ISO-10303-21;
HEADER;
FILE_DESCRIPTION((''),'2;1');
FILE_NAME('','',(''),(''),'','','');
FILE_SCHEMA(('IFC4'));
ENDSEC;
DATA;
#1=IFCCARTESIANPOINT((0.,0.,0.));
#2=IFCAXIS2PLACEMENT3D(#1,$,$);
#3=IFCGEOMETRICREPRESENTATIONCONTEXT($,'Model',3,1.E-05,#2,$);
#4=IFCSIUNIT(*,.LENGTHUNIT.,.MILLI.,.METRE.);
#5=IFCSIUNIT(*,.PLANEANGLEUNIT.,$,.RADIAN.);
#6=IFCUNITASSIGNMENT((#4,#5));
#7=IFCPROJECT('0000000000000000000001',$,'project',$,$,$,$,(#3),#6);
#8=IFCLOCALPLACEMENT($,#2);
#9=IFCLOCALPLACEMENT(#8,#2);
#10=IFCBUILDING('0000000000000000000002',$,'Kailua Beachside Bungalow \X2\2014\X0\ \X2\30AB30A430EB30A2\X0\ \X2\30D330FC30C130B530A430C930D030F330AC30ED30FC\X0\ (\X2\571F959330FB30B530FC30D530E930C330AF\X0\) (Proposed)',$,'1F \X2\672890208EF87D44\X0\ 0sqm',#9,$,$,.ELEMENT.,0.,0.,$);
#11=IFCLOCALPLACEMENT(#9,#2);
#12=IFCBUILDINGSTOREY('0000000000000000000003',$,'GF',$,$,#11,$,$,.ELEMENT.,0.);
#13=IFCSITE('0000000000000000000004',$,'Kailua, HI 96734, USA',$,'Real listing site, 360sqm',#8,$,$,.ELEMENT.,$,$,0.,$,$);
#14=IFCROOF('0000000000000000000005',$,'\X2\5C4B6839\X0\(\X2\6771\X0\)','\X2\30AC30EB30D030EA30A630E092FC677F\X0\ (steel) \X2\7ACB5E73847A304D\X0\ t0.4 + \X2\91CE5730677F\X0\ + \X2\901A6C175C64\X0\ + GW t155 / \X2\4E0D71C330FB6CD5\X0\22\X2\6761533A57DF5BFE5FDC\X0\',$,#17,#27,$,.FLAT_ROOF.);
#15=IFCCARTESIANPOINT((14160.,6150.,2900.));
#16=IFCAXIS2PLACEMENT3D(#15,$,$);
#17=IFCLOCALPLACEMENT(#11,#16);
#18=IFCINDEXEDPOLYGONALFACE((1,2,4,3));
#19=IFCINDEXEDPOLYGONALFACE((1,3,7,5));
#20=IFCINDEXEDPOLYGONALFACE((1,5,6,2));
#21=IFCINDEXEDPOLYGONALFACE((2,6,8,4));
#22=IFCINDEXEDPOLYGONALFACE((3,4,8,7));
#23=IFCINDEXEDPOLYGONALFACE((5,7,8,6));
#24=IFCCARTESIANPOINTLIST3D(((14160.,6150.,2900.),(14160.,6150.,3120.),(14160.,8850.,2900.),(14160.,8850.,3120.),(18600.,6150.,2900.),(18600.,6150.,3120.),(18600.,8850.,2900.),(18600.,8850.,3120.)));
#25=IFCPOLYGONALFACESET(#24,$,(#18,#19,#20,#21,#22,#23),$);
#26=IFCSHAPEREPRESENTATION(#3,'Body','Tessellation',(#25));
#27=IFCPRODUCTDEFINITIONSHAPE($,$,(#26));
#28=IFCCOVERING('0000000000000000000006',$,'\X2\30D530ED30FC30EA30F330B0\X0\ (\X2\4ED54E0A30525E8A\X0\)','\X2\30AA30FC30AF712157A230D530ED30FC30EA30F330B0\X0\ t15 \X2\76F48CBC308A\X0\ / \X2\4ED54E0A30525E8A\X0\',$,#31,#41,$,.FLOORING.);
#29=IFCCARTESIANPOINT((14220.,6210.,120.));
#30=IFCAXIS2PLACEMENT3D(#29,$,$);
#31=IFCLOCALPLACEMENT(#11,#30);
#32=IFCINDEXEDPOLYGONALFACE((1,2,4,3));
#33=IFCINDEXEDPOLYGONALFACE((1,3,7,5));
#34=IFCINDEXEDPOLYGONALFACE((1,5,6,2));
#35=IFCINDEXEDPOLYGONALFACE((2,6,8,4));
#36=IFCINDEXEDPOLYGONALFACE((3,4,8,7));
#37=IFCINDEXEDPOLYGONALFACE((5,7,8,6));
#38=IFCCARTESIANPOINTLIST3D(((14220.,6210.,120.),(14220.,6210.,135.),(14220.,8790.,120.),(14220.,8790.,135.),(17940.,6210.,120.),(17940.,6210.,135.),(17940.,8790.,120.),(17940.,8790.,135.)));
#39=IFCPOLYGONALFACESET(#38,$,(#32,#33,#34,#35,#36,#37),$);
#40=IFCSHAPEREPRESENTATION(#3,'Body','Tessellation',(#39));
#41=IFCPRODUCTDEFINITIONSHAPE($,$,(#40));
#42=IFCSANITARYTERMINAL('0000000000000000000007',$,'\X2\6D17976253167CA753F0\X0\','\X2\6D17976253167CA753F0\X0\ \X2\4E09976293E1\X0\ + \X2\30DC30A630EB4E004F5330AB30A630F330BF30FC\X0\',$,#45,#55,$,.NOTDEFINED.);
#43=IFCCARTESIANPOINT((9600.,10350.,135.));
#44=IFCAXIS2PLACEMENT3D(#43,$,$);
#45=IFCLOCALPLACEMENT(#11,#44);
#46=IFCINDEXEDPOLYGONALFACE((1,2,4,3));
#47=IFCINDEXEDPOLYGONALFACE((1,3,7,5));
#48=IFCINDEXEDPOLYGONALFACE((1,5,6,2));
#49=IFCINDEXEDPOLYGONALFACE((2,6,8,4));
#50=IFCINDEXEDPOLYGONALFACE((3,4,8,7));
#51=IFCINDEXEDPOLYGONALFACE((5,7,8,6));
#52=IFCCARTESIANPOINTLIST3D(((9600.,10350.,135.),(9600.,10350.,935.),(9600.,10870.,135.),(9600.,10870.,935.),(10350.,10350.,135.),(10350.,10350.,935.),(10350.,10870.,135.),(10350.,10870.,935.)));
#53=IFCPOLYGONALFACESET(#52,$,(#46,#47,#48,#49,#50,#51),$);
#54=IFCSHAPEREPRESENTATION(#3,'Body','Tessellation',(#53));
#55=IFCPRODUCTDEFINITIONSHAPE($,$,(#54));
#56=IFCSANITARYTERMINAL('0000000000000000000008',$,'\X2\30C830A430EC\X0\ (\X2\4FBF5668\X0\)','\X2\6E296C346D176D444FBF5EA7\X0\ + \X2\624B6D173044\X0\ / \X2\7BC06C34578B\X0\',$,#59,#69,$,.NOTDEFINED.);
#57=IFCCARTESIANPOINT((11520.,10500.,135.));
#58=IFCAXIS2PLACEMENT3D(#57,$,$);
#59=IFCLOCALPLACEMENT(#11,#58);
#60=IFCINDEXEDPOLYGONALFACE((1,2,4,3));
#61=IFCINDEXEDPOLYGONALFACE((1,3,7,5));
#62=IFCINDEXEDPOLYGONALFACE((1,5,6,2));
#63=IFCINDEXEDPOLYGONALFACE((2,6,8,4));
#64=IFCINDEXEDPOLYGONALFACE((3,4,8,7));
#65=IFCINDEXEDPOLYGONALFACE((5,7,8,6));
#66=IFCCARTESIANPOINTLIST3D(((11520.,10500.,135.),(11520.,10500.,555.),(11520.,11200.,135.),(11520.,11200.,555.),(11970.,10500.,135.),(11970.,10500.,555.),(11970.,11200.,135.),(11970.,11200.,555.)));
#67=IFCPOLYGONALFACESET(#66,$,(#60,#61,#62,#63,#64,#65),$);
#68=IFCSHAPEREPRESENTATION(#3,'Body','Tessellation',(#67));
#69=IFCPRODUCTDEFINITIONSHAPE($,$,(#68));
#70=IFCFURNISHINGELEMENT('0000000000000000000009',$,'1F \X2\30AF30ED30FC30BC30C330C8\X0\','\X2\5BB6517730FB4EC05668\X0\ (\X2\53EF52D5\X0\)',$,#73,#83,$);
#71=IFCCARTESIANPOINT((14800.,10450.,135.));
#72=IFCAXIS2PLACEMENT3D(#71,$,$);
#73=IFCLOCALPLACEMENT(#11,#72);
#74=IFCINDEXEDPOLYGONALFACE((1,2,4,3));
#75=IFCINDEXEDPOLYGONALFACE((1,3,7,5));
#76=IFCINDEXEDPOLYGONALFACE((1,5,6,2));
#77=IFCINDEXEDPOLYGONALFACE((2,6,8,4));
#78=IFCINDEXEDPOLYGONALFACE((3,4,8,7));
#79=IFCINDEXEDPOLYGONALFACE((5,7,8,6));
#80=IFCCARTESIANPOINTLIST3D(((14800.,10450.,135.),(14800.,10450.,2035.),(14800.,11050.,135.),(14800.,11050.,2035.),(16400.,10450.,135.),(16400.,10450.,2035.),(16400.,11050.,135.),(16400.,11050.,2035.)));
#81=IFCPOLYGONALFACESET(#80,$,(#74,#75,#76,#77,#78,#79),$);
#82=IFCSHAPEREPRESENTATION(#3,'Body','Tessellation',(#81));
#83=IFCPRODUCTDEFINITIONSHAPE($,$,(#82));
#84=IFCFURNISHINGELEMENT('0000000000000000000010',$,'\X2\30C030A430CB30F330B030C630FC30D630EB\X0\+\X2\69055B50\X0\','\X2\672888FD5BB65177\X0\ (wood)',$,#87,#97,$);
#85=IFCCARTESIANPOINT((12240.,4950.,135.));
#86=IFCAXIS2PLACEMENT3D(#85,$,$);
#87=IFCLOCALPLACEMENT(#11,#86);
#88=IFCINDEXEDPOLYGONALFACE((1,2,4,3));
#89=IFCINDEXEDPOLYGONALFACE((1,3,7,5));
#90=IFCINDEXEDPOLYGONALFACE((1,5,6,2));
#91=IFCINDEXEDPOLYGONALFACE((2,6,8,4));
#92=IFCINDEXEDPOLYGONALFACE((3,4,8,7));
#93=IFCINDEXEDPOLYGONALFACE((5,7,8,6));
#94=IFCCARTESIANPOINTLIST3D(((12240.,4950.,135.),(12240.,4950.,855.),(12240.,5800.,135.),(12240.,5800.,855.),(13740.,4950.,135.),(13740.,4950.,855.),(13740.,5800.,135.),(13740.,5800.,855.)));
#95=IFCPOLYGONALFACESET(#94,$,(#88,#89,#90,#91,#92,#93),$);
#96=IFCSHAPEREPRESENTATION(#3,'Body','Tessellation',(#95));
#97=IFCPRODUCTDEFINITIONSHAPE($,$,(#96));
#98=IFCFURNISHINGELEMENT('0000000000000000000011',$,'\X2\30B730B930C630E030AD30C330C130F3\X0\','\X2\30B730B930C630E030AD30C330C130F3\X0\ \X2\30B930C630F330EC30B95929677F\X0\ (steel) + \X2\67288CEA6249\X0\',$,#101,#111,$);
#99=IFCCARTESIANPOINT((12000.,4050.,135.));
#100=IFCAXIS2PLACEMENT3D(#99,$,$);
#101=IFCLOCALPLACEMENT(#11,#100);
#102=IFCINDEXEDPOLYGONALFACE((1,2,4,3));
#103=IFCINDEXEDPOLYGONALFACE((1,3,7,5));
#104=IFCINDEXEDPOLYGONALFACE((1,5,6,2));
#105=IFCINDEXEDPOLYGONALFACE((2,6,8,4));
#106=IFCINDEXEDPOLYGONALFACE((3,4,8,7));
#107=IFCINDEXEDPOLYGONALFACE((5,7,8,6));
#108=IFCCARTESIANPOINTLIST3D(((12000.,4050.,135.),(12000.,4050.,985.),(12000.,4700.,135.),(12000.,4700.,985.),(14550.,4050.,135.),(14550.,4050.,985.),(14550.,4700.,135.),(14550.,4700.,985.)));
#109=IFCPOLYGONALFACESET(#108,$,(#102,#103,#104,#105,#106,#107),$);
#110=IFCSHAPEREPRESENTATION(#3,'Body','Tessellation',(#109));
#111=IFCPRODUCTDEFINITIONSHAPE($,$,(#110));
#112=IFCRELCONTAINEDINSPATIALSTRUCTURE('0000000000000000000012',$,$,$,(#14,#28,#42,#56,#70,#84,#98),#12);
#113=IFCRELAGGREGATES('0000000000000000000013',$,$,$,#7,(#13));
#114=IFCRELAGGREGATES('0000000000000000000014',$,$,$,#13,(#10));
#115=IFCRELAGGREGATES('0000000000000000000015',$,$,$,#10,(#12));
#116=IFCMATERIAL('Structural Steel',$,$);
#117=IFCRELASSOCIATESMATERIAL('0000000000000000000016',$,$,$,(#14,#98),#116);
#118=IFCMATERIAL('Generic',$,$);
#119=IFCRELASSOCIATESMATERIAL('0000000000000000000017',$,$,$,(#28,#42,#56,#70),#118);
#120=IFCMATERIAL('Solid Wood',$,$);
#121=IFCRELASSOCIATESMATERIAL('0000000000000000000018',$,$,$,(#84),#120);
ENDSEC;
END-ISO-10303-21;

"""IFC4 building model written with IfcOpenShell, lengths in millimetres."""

from ifc_helpers import new_model, si_unit, frame, frame_2d, origin, place, context, project, spatial, rectangle, extrude, material, element, save


model = new_model("IFC4")

# Units and contexts
model_context = context("Model", 3, precision=1e-05, world=origin())
ifc_project = project(units=[si_unit("LENGTHUNIT", "METRE", prefix="MILLI"), si_unit("PLANEANGLEUNIT", "RADIAN")], contexts=[model_context])

# Site, building, storey
site_placement = place(None, origin())
site = spatial("IfcSite", under=ifc_project, at=site_placement, Name="Kailua, HI 96734, USA", ObjectType="Real listing site, 360sqm", CompositionType="ELEMENT", RefElevation=0.0)
building_placement = place(site_placement, origin())
building = spatial("IfcBuilding", under=site, at=building_placement, Name="Kailua Beachside Bungalow — カイルア ビーチサイドバンガロー (土間・サーフラック) (Proposed)", ObjectType="1F 木造軸組 0sqm", CompositionType="ELEMENT", ElevationOfRefHeight=0.0, ElevationOfTerrain=0.0)
storey_placement = place(building_placement, origin())
storey = spatial("IfcBuildingStorey", under=building, at=storey_placement, Name="GF", CompositionType="ELEMENT", Elevation=0.0)

# Shared definitions
ifc_material_1 = material(Name="Solid Wood")

# Roof
ifc_material_2 = material(Name="Structural Steel")
roof_placement = place(storey_placement, frame((14160.0, 6150.0, 2900.0)))
element("IfcRoof", 1, at=roof_placement, inside=storey, material=ifc_material_2, Name="屋根(東)", Description="ガルバリウム鋼板 (steel) 立平葺き t0.4 + 野地板 + 通気層 + GW t155 / 不燃・法22条区域対応", PredefinedType="FLAT_ROOF", context=model_context, shape_type="SweptSolid", body=[
    extrude(rectangle(XDim=4440.0, YDim=2700.0, at=frame_2d((2220.0, 1350.0))), frame((14160.0, 6150.0, 2900.0)), (0.0, 0.0, 1.0), 220.0),
])

# Covering
ifc_material_3 = material(Name="Generic")
covering_placement = place(storey_placement, frame((14220.0, 6210.0, 120.0)))
element("IfcCovering", 2, at=covering_placement, inside=storey, material=ifc_material_3, Name="フローリング (仕上げ床)", Description="オーク無垢フローリング t15 直貼り / 仕上げ床", PredefinedType="FLOORING", context=model_context, shape_type="SweptSolid", body=[
    extrude(rectangle(XDim=3720.0, YDim=2580.0, at=frame_2d((1860.0, 1290.0))), frame((14220.0, 6210.0, 120.0)), (0.0, 0.0, 1.0), 15.0),
])

# Sanitary terminals
sanitary_terminal_1_placement = place(storey_placement, frame((9600.0, 10350.0, 135.0)))
element("IfcSanitaryTerminal", 3, at=sanitary_terminal_1_placement, inside=storey, material=ifc_material_3, Name="洗面化粧台", Description="洗面化粧台 三面鏡 + ボウル一体カウンター", PredefinedType="NOTDEFINED", context=model_context, shape_type="SweptSolid", body=[
    extrude(rectangle(XDim=750.0, YDim=520.0, at=frame_2d((375.0, 260.0))), frame((9600.0, 10350.0, 135.0)), (0.0, 0.0, 1.0), 800.0),
])
sanitary_terminal_2_placement = place(storey_placement, frame((11520.0, 10500.0, 135.0)))
element("IfcSanitaryTerminal", 4, at=sanitary_terminal_2_placement, inside=storey, material=ifc_material_3, Name="トイレ (便器)", Description="温水洗浄便座 + 手洗い / 節水型", PredefinedType="NOTDEFINED", context=model_context, shape_type="SweptSolid", body=[
    extrude(rectangle(XDim=450.0, YDim=700.0, at=frame_2d((225.0, 350.0))), frame((11520.0, 10500.0, 135.0)), (0.0, 0.0, 1.0), 420.0),
])

# Furnishing elements
furnishing_1_placement = place(storey_placement, frame((14800.0, 10450.0, 135.0)))
element("IfcFurnishingElement", 5, at=furnishing_1_placement, inside=storey, material=ifc_material_3, Name="1F クローゼット", Description="家具・什器 (可動)", context=model_context, shape_type="SweptSolid", body=[
    extrude(rectangle(XDim=1600.0, YDim=600.0, at=frame_2d((800.0, 300.0))), frame((14800.0, 10450.0, 135.0)), (0.0, 0.0, 1.0), 1900.0),
])
furnishing_2_placement = place(storey_placement, frame((12240.0, 4950.0, 135.0)))
element("IfcFurnishingElement", 6, at=furnishing_2_placement, inside=storey, material=ifc_material_1, Name="ダイニングテーブル+椅子", Description="木製家具 (wood)", context=model_context, shape_type="SweptSolid", body=[
    extrude(rectangle(XDim=1500.0, YDim=850.0, at=frame_2d((750.0, 425.0))), frame((12240.0, 4950.0, 135.0)), (0.0, 0.0, 1.0), 720.0),
])
furnishing_3_placement = place(storey_placement, frame((12000.0, 4050.0, 135.0)))
element("IfcFurnishingElement", 7, at=furnishing_3_placement, inside=storey, material=ifc_material_2, Name="システムキッチン", Description="システムキッチン ステンレス天板 (steel) + 木質扉", context=model_context, shape_type="SweptSolid", body=[
    extrude(rectangle(XDim=2550.0, YDim=650.0, at=frame_2d((1275.0, 325.0))), frame((12000.0, 4050.0, 135.0)), (0.0, 0.0, 1.0), 850.0),
])

save(model, "model.ifc")
